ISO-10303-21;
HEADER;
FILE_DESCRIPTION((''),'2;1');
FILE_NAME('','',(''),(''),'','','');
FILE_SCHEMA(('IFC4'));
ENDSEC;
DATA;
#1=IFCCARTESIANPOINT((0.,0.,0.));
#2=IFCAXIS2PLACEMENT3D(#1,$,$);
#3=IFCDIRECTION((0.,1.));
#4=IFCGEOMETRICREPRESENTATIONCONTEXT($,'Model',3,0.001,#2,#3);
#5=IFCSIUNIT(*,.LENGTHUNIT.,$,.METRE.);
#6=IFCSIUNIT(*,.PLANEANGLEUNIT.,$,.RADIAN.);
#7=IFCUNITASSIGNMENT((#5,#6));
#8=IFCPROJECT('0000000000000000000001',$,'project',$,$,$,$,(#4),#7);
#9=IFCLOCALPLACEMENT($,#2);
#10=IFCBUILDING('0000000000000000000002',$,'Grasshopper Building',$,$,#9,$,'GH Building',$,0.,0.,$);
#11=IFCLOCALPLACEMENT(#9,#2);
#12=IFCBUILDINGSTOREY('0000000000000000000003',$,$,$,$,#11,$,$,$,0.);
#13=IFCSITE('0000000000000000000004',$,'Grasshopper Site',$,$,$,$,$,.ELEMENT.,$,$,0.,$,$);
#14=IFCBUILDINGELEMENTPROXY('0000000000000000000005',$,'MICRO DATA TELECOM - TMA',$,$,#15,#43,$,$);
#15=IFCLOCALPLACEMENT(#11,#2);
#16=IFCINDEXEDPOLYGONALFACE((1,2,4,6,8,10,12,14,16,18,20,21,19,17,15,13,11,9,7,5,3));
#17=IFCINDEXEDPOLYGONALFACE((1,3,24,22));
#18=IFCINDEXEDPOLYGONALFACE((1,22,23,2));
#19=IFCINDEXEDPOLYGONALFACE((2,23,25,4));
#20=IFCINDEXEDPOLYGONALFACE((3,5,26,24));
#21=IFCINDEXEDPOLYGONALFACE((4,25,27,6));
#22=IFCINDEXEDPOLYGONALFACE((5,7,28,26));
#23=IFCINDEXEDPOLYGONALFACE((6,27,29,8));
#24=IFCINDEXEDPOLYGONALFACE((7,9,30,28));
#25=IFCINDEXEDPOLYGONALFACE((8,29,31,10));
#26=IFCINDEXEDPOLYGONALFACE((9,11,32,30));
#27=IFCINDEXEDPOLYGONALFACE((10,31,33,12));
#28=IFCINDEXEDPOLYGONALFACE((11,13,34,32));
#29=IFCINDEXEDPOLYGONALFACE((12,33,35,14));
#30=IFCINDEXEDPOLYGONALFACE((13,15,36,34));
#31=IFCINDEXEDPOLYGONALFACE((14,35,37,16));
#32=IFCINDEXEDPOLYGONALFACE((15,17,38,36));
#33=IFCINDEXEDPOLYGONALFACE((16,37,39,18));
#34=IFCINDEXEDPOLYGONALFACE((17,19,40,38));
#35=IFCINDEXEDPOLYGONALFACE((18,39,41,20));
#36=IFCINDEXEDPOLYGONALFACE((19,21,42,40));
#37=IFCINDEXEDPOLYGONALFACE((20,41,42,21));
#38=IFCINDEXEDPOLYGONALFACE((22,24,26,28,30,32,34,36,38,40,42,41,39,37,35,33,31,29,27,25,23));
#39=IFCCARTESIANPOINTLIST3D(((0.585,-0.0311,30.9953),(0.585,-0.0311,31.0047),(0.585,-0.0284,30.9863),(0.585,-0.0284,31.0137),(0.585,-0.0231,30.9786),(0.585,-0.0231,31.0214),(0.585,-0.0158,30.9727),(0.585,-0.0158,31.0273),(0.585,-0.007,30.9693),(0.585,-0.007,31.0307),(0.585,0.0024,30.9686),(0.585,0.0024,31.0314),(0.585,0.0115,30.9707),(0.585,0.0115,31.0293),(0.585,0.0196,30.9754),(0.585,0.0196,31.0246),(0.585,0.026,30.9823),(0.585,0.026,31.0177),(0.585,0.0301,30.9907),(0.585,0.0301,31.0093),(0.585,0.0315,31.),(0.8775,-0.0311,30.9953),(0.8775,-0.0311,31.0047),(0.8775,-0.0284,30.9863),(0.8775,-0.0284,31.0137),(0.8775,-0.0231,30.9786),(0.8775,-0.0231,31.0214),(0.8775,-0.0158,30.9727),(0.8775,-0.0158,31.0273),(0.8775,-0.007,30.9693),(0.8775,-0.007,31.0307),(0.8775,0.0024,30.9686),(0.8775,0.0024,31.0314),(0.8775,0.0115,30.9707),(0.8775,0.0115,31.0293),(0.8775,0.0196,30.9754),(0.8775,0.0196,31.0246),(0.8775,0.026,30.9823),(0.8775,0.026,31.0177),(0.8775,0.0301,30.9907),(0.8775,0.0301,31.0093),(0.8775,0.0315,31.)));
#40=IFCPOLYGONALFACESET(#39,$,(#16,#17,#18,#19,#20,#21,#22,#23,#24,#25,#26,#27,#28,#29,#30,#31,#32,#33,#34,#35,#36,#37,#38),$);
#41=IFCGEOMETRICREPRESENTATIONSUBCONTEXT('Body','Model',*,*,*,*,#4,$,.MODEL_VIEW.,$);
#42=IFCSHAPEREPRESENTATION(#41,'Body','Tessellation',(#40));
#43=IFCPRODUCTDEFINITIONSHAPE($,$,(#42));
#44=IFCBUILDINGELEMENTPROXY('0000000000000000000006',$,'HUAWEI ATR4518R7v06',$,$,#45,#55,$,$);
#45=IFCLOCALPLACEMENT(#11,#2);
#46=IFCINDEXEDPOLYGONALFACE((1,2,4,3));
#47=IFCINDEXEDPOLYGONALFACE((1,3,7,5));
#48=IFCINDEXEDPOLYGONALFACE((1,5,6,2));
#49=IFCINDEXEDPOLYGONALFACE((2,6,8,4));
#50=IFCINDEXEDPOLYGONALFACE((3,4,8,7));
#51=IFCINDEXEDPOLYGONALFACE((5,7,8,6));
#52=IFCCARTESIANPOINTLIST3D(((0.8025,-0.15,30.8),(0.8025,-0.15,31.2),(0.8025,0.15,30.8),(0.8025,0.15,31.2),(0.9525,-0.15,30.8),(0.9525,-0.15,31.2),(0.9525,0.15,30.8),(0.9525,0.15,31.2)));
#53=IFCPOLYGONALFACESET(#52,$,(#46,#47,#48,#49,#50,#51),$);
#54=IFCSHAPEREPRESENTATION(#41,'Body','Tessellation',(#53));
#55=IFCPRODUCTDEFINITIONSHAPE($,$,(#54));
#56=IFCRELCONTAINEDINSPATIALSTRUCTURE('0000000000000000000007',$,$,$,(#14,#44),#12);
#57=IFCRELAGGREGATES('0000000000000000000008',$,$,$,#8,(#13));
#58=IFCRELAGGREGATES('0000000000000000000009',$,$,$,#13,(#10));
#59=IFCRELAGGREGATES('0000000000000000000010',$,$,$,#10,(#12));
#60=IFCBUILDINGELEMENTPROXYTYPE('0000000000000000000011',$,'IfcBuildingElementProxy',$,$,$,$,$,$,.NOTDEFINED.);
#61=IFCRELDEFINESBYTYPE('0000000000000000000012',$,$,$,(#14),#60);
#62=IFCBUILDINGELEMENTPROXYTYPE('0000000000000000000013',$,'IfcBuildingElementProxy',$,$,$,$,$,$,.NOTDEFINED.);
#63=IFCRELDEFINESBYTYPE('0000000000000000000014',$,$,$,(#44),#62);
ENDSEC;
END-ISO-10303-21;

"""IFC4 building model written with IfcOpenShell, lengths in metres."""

from ifc_helpers import new_model, si_unit, direction, frame, frame_2d, origin, place, context, subcontext, project, spatial, rectangle, circle, extrude, source, transform, mapped, type_object, type_shapes, element, save


model = new_model("IFC4")

# Units and contexts
model_context = context("Model", 3, precision=0.001, world=origin(), true_north=direction((0.0, 1.0)))
body_context = subcontext(model_context, "Body", "Model", "MODEL_VIEW")
ifc_project = project(units=[si_unit("LENGTHUNIT", "METRE"), si_unit("PLANEANGLEUNIT", "RADIAN")], contexts=[model_context])

# Site, building, storey
site = spatial("IfcSite", under=ifc_project, Name="Grasshopper Site", CompositionType="ELEMENT", RefElevation=0.0)
building_placement = place(None, origin())
building = spatial("IfcBuilding", under=site, at=building_placement, Name="Grasshopper Building", LongName="GH Building", ElevationOfRefHeight=0.0, ElevationOfTerrain=0.0)
storey_placement = place(building_placement, origin())
storey = spatial("IfcBuildingStorey", under=building, at=storey_placement, Elevation=0.0)

# Building element proxies
building_element_proxy_type_1 = type_object("IfcBuildingElementProxyType", Name="IfcBuildingElementProxy", PredefinedType="NOTDEFINED")
shared_shape_1 = source(origin(), body_context, "Body", "SweptSolid", [
    extrude(circle(Radius=0.0315), frame((0.585, 0.0, 31.0), z_axis=(1.0, 0.0, 0.0), x_axis=(0.0, 1.0, 0.0)), (0.0, 0.0, 1.0), 0.2925),
])
type_shapes(building_element_proxy_type_1, [shared_shape_1])
for number, where, name in (
    (1, (0.0, 0.0, 0.0), "MICRO DATA TELECOM - TMA"),
):
    element("IfcBuildingElementProxy", number, at=place(storey_placement, frame(where)), inside=storey, type_object=building_element_proxy_type_1, Name=name, context=body_context, shape_type="MappedRepresentation", body=[
        mapped(shared_shape_1, transform((0.0, 0.0, 0.0), scale=1.0)),
    ])
building_element_proxy_type_2 = type_object("IfcBuildingElementProxyType", Name="IfcBuildingElementProxy", PredefinedType="NOTDEFINED")
shared_shape_2 = source(origin(), body_context, "Body", "SweptSolid", [
    extrude(rectangle(XDim=0.4, YDim=0.3, at=frame_2d((0.0, 0.0), x_axis=(0.0, 1.0))), frame((0.9525, 0.0, 31.0), z_axis=(-1.0, 0.0, 0.0), x_axis=(0.0, 1.0, 0.0)), (0.0, 0.0, 1.0), 0.15),
])
type_shapes(building_element_proxy_type_2, [shared_shape_2])
for number, where, name in (
    (2, (0.0, 0.0, 0.0), "HUAWEI ATR4518R7v06"),
):
    element("IfcBuildingElementProxy", number, at=place(storey_placement, frame(where)), inside=storey, type_object=building_element_proxy_type_2, Name=name, context=body_context, shape_type="MappedRepresentation", body=[
        mapped(shared_shape_2, transform((0.0, 0.0, 0.0), scale=1.0)),
    ])

save(model, "model.ifc")
